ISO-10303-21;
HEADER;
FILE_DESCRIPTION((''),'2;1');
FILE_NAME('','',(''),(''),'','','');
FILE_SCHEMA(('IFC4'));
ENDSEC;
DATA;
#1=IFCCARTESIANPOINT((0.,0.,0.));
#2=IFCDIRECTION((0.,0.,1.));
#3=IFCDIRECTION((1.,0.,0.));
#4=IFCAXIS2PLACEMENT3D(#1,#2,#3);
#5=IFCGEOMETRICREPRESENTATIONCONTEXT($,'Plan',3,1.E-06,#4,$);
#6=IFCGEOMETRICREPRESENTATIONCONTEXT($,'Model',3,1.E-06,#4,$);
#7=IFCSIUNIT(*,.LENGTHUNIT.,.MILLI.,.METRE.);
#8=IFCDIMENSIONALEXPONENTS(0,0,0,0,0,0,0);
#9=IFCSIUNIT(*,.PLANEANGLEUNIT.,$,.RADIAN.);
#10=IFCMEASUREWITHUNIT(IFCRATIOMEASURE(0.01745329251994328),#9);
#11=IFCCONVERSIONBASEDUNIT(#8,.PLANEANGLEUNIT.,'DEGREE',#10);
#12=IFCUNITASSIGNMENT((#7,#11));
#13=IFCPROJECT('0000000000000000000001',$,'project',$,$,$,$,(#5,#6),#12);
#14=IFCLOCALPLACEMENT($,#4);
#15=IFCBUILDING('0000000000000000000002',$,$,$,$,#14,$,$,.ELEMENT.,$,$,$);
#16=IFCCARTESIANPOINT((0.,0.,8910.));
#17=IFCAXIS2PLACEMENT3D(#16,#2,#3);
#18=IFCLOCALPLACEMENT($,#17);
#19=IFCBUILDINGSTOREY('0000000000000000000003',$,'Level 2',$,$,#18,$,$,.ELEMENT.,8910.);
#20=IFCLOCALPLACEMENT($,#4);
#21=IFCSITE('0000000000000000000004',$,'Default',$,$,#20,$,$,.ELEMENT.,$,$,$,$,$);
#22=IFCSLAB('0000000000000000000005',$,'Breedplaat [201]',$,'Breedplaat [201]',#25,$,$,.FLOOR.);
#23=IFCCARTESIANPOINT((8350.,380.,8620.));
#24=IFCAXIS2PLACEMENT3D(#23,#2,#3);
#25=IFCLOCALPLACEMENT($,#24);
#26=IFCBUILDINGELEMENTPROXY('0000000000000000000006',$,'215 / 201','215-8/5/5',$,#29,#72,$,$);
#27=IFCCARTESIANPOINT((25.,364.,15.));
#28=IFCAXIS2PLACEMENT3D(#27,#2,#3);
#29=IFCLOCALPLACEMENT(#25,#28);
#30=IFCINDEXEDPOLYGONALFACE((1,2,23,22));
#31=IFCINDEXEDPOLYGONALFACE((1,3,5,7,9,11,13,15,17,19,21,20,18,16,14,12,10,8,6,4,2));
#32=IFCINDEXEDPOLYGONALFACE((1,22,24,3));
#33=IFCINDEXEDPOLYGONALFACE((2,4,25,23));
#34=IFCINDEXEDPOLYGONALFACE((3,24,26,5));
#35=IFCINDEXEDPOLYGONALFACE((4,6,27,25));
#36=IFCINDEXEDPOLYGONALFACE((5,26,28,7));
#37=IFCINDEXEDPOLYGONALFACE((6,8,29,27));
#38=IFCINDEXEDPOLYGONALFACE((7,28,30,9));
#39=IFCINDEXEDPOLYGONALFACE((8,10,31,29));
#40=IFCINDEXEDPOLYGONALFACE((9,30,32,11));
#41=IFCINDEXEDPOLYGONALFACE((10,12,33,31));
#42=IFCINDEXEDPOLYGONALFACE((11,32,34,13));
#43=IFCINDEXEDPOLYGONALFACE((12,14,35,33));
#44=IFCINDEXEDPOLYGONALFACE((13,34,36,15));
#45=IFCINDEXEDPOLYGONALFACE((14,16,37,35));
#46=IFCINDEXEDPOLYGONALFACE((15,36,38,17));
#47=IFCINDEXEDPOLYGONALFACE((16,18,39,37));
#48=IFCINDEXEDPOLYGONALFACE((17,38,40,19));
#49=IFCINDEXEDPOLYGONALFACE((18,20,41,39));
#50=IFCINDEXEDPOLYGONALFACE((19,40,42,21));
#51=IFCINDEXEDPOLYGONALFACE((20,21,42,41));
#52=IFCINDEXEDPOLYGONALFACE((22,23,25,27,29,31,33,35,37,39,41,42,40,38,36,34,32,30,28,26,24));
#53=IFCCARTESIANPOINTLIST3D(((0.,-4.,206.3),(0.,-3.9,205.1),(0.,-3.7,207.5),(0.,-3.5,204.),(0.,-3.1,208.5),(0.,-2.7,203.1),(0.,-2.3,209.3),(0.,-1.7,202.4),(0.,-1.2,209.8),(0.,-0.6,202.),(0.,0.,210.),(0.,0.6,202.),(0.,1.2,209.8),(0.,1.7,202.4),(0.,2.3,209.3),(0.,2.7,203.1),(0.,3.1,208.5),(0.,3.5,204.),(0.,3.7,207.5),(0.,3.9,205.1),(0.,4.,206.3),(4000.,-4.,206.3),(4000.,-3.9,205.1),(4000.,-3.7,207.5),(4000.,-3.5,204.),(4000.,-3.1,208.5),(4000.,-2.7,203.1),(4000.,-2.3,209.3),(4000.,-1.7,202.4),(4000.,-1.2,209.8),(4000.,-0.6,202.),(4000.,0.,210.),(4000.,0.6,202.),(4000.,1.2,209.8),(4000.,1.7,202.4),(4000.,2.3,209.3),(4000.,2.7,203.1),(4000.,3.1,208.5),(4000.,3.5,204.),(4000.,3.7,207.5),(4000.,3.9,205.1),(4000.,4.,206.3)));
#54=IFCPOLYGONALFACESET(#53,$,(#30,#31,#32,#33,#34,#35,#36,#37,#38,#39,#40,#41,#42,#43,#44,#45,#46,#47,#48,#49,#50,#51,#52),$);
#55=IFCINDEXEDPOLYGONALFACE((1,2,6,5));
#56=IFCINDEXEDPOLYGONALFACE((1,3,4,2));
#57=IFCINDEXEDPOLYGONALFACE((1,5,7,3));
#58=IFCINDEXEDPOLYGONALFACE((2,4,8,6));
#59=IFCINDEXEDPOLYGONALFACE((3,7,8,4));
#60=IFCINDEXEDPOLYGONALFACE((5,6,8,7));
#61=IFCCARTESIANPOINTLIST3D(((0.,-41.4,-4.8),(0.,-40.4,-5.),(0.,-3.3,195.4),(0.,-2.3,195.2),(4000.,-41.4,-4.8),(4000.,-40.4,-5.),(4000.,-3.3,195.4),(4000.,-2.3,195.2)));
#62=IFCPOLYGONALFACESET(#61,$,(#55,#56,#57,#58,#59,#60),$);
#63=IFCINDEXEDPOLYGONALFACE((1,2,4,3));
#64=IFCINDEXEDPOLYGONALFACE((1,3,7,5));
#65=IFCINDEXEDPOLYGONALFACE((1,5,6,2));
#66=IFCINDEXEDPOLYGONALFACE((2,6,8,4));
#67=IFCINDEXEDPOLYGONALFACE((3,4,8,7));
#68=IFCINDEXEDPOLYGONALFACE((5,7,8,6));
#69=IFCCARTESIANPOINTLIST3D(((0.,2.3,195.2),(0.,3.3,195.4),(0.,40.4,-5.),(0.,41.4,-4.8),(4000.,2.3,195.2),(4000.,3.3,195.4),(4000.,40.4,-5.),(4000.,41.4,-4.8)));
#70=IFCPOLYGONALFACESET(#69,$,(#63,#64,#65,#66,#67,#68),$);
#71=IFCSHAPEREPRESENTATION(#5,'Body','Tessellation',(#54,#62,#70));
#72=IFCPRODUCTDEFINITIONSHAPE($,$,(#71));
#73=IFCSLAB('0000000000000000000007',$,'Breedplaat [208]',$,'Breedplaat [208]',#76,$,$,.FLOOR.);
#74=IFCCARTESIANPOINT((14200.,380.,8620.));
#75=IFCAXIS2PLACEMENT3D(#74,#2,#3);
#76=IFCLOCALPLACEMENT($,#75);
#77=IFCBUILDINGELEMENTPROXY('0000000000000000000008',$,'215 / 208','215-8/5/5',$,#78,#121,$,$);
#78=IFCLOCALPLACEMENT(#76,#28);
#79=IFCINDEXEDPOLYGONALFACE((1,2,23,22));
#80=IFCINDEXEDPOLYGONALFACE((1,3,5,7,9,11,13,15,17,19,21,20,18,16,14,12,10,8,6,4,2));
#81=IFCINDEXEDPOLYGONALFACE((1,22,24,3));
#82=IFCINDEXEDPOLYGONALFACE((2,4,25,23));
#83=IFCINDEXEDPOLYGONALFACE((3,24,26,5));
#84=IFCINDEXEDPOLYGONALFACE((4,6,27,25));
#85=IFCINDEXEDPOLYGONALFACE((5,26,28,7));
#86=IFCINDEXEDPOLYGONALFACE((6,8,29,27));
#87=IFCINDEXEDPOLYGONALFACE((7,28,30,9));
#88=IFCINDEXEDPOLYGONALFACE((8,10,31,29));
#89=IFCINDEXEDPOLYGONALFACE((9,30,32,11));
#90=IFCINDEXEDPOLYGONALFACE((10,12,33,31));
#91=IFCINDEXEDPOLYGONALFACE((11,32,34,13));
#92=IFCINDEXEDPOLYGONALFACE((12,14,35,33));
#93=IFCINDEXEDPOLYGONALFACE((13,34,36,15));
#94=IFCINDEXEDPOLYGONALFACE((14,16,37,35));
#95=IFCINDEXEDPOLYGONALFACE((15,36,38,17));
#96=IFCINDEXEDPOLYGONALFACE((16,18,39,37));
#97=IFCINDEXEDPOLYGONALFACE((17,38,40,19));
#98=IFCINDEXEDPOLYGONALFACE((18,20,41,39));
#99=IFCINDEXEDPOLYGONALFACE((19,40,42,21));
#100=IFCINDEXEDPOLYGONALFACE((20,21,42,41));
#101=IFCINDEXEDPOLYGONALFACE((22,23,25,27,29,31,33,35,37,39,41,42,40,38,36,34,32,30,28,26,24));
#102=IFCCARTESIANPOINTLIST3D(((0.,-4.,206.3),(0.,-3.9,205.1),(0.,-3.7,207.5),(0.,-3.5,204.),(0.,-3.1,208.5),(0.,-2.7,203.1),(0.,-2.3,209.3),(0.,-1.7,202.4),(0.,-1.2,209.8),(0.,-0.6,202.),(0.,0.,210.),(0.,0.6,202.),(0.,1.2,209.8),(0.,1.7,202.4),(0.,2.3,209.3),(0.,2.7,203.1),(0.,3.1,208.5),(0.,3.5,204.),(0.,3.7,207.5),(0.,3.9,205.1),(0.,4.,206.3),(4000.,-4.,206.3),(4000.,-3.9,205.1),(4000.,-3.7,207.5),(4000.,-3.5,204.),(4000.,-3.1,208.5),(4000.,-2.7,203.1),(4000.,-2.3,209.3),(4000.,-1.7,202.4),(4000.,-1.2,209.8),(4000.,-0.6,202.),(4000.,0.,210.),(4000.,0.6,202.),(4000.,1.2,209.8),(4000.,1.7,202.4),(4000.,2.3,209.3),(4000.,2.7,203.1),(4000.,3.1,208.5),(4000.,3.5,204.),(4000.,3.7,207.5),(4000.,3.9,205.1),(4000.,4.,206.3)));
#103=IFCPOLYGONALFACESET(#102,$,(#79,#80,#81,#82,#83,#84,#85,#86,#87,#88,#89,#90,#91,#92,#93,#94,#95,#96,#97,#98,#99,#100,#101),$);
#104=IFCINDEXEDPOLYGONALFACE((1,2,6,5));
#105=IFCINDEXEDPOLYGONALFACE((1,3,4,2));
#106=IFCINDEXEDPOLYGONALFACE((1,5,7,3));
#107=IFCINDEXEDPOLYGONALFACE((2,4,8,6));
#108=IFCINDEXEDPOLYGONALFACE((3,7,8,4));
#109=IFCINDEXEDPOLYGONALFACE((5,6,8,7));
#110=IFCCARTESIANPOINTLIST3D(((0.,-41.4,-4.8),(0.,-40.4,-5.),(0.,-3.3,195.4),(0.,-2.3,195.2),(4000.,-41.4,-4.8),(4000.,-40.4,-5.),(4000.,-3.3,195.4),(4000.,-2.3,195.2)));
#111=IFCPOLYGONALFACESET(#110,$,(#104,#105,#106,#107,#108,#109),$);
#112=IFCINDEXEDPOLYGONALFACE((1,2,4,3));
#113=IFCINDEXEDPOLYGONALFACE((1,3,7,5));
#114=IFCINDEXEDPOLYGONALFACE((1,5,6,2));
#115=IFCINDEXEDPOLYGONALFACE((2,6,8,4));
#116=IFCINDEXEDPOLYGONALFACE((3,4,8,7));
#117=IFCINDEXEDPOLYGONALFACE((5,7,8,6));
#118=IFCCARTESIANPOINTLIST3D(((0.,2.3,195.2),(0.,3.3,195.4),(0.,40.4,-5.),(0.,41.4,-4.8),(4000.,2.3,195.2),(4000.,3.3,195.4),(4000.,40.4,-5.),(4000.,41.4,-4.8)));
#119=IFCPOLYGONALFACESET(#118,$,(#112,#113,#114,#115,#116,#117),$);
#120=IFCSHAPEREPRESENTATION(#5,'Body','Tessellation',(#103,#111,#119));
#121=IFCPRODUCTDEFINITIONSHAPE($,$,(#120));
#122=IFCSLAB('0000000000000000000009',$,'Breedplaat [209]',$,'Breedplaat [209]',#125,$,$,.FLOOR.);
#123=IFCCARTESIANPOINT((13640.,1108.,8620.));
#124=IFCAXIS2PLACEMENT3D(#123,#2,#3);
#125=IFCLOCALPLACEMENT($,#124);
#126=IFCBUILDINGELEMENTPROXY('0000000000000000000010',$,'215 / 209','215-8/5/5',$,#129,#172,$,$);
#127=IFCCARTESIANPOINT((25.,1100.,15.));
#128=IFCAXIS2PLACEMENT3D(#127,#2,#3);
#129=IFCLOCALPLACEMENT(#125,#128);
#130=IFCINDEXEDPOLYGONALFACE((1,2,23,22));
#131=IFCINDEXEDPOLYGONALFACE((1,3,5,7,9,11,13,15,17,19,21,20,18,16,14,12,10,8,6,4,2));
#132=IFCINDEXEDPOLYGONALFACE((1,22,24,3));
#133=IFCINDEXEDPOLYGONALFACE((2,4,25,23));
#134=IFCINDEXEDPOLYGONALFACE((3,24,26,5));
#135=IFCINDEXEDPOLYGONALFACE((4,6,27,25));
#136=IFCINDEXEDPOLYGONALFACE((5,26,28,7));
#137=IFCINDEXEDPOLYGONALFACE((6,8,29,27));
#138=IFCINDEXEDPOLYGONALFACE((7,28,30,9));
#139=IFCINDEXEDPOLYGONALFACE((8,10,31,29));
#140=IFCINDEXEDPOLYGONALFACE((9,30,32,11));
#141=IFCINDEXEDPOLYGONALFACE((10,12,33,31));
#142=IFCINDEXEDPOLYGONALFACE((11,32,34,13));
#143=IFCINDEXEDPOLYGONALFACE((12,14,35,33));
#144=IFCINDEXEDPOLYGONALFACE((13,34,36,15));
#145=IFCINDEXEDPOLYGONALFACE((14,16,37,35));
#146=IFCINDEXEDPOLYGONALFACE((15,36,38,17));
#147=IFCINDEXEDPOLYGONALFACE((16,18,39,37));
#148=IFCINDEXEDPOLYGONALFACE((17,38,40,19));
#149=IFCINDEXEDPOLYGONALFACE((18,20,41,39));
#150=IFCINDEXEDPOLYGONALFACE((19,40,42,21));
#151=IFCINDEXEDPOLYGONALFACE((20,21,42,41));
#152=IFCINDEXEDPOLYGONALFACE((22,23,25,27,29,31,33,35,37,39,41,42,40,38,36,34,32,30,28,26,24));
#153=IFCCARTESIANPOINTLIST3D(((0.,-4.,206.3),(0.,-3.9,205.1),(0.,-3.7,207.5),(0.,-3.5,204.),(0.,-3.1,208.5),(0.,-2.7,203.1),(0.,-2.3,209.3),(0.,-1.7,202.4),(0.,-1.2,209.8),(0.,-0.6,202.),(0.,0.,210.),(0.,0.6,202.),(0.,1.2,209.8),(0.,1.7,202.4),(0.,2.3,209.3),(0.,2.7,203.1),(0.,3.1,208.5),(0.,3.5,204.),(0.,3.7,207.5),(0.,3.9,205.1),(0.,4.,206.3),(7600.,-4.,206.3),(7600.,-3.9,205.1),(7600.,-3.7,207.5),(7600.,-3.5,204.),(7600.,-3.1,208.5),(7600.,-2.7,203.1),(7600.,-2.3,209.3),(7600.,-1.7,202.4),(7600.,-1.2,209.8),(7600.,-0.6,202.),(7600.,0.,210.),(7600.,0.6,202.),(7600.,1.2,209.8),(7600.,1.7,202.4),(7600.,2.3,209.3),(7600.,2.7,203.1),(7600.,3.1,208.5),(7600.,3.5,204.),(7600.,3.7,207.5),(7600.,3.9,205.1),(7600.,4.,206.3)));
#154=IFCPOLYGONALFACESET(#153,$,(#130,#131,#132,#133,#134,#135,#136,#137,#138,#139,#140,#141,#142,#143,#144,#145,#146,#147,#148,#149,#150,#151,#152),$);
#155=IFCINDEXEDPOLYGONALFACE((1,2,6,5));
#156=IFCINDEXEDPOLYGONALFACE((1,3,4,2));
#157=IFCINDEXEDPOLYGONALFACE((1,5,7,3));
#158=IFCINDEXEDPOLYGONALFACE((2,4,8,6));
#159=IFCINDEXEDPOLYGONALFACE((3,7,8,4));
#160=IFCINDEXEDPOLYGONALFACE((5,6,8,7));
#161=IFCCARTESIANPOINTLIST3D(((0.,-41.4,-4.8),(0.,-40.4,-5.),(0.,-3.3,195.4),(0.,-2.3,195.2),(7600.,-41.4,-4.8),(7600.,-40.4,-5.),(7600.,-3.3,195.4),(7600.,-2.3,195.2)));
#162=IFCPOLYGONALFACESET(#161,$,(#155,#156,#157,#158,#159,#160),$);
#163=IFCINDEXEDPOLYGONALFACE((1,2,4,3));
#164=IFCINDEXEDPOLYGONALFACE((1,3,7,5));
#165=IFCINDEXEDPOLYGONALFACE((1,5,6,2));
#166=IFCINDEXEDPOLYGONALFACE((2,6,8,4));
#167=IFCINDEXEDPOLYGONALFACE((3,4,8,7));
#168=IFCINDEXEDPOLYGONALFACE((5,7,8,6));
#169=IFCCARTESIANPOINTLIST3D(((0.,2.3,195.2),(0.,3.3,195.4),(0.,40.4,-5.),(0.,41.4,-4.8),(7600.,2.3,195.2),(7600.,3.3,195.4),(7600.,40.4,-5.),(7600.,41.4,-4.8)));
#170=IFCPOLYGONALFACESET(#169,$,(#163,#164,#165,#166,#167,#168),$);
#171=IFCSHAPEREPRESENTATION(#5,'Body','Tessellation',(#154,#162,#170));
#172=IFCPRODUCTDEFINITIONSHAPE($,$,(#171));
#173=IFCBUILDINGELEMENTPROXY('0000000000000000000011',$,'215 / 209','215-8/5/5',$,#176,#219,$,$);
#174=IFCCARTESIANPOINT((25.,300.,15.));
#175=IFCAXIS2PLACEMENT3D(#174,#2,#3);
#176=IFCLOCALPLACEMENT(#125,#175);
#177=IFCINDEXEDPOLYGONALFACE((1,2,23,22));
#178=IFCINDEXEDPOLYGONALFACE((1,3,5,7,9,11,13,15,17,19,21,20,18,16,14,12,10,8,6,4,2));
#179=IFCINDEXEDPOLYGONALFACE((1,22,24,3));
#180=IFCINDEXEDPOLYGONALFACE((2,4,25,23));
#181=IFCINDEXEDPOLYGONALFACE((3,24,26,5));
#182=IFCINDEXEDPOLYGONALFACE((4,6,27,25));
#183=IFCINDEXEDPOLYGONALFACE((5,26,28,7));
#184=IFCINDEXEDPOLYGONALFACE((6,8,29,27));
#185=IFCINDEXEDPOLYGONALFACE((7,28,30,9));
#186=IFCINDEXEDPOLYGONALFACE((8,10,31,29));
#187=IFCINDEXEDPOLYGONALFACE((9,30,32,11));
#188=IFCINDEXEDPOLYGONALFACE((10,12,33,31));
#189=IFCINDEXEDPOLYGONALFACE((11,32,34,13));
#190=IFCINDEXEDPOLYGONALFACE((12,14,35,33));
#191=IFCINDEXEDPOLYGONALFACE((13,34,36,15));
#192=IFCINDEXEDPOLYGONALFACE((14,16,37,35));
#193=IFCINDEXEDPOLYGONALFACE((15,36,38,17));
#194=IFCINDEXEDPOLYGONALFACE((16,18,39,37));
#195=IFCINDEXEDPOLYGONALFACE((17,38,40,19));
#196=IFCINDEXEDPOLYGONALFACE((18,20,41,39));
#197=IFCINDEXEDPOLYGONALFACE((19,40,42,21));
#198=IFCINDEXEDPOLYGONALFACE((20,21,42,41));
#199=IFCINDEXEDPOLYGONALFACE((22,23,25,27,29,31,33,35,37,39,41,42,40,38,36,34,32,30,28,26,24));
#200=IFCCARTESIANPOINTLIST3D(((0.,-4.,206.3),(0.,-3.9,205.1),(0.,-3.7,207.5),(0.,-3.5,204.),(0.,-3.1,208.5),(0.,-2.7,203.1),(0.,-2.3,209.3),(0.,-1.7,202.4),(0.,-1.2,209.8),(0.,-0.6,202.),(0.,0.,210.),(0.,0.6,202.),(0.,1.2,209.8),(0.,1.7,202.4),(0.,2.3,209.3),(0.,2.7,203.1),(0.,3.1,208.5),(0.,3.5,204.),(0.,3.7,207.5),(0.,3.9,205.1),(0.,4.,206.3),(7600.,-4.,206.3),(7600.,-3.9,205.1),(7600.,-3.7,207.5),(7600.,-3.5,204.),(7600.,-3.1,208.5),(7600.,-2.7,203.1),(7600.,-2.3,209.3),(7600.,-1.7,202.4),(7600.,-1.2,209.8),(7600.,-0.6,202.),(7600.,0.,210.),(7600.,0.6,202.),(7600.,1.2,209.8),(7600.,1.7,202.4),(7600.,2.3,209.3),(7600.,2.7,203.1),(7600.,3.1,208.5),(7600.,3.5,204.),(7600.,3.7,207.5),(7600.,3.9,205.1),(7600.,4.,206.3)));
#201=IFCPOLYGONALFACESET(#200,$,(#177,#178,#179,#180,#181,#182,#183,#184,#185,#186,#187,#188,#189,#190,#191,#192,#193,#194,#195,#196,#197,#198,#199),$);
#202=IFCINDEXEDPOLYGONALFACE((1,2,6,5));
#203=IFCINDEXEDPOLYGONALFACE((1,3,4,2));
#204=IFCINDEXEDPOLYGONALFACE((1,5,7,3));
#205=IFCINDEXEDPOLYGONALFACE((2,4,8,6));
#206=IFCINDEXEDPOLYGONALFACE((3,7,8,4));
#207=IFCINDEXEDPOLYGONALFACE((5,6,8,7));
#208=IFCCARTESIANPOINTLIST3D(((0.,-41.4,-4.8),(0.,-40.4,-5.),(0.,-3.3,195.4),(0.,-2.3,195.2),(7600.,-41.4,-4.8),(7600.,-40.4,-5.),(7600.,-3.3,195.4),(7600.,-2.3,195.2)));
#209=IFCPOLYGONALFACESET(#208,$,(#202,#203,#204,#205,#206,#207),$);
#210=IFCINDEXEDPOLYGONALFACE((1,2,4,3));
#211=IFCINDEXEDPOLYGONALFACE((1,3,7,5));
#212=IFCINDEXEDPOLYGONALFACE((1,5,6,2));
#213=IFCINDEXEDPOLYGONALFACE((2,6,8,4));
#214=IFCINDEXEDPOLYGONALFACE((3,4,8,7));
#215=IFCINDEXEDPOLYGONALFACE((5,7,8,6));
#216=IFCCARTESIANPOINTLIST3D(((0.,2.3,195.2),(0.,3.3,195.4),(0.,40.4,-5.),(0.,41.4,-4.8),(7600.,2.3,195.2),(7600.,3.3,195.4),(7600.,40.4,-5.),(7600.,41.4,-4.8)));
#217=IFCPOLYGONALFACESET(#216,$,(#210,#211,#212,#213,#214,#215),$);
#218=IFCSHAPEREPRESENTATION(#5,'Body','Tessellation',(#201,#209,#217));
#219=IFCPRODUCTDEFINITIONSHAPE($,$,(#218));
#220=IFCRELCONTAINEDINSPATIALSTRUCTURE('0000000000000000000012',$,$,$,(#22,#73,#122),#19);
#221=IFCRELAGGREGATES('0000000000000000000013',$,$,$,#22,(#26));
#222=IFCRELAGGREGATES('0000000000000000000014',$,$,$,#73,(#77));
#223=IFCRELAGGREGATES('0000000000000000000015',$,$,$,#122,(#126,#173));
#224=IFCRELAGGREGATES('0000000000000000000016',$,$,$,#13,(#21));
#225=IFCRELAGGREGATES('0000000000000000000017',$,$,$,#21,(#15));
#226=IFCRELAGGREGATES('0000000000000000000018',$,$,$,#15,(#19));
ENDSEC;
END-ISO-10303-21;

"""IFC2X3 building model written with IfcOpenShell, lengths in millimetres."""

from ifc_helpers import new_model, entity, si_unit, converted_unit, frame, origin_with_axes, origin_2d_with_axis, place, context, project, spatial, rectangle, circle, extrude, element, aggregate, save


model = new_model("IFC2X3")

# Units and contexts
plan_context = context("Plan", 3, precision=1e-06, world=origin_with_axes())
model_context = context("Model", 3, precision=1e-06, world=origin_with_axes())
ifc_project = project(units=[si_unit("LENGTHUNIT", "METRE", prefix="MILLI"), converted_unit("PLANEANGLEUNIT", "DEGREE", entity("IfcRatioMeasure", 0.01745329251994328), si_unit("PLANEANGLEUNIT", "RADIAN"), dimensions=[0, 0, 0, 0, 0, 0, 0])], contexts=[plan_context, model_context])

# Site, building, storey
site_placement = place(None, origin_with_axes())
site = spatial("IfcSite", under=ifc_project, at=site_placement, Name="Default", CompositionType="ELEMENT")
building_placement = place(None, origin_with_axes())
building = spatial("IfcBuilding", under=site, at=building_placement, CompositionType="ELEMENT")
storey_placement = place(None, frame((0.0, 0.0, 8910.0), z_axis=(0.0, 0.0, 1.0), x_axis=(1.0, 0.0, 0.0)))
storey = spatial("IfcBuildingStorey", under=building, at=storey_placement, Name="Level 2", CompositionType="ELEMENT", Elevation=8910.0)

# Slab, building element proxy
slab_1_placement = place(None, frame((8350.0, 380.0, 8620.0), z_axis=(0.0, 0.0, 1.0), x_axis=(1.0, 0.0, 0.0)))
slab_1 = element("IfcSlab", 1, at=slab_1_placement, inside=storey, Name="Breedplaat [201]", ObjectType="Breedplaat [201]", PredefinedType="FLOOR")
proxy_1_placement = place(slab_1_placement, frame((25.0, 364.0, 15.0), z_axis=(0.0, 0.0, 1.0), x_axis=(1.0, 0.0, 0.0)))
proxy_1 = element("IfcBuildingElementProxy", 2, at=proxy_1_placement, Name="215 / 201", Description="215-8/5/5", context=plan_context, shape_type="SweptSolid", body=[
    extrude(circle(Radius=4.0, at=origin_2d_with_axis()), frame((0.0, 0.0, 206.0), z_axis=(1.0, 0.0, 0.0), x_axis=(0.0, 0.0, 1.0)), (0.0, 0.0, 1.0), 4000.0),
    extrude(rectangle(XDim=203.8, YDim=1.0, at=origin_2d_with_axis()), frame((0.0, -21.9, 95.2), z_axis=(1.0, 0.0, 0.0), x_axis=(0.0, 0.187112, 0.982339)), (0.0, 0.0, 1.0), 4000.0),
    extrude(rectangle(XDim=203.8, YDim=1.0, at=origin_2d_with_axis()), frame((0.0, 21.9, 95.2), z_axis=(1.0, 0.0, 0.0), x_axis=(0.0, -0.187112, 0.982339)), (0.0, 0.0, 1.0), 4000.0),
])
aggregate(slab_1, [proxy_1])

# Slab, building element proxy
slab_2_placement = place(None, frame((14200.0, 380.0, 8620.0), z_axis=(0.0, 0.0, 1.0), x_axis=(1.0, 0.0, 0.0)))
slab_2 = element("IfcSlab", 3, at=slab_2_placement, inside=storey, Name="Breedplaat [208]", ObjectType="Breedplaat [208]", PredefinedType="FLOOR")
proxy_2_placement = place(slab_2_placement, frame((25.0, 364.0, 15.0), z_axis=(0.0, 0.0, 1.0), x_axis=(1.0, 0.0, 0.0)))
proxy_2 = element("IfcBuildingElementProxy", 4, at=proxy_2_placement, Name="215 / 208", Description="215-8/5/5", context=plan_context, shape_type="SweptSolid", body=[
    extrude(circle(Radius=4.0, at=origin_2d_with_axis()), frame((0.0, 0.0, 206.0), z_axis=(1.0, 0.0, 0.0), x_axis=(0.0, 0.0, 1.0)), (0.0, 0.0, 1.0), 4000.0),
    extrude(rectangle(XDim=203.8, YDim=1.0, at=origin_2d_with_axis()), frame((0.0, -21.9, 95.2), z_axis=(1.0, 0.0, 0.0), x_axis=(0.0, 0.187112, 0.982339)), (0.0, 0.0, 1.0), 4000.0),
    extrude(rectangle(XDim=203.8, YDim=1.0, at=origin_2d_with_axis()), frame((0.0, 21.9, 95.2), z_axis=(1.0, 0.0, 0.0), x_axis=(0.0, -0.187112, 0.982339)), (0.0, 0.0, 1.0), 4000.0),
])
aggregate(slab_2, [proxy_2])

# Slab, building element proxies
slab_3_placement = place(None, frame((13640.0, 1108.0, 8620.0), z_axis=(0.0, 0.0, 1.0), x_axis=(1.0, 0.0, 0.0)))
slab_3 = element("IfcSlab", 5, at=slab_3_placement, inside=storey, Name="Breedplaat [209]", ObjectType="Breedplaat [209]", PredefinedType="FLOOR")
proxy_3_placement = place(slab_3_placement, frame((25.0, 1100.0, 15.0), z_axis=(0.0, 0.0, 1.0), x_axis=(1.0, 0.0, 0.0)))
proxy_3 = element("IfcBuildingElementProxy", 6, at=proxy_3_placement, Name="215 / 209", Description="215-8/5/5", context=plan_context, shape_type="SweptSolid", body=[
    extrude(circle(Radius=4.0, at=origin_2d_with_axis()), frame((0.0, 0.0, 206.0), z_axis=(1.0, 0.0, 0.0), x_axis=(0.0, 0.0, 1.0)), (0.0, 0.0, 1.0), 7600.0),
    extrude(rectangle(XDim=203.8, YDim=1.0, at=origin_2d_with_axis()), frame((0.0, -21.9, 95.2), z_axis=(1.0, 0.0, 0.0), x_axis=(0.0, 0.187112, 0.982339)), (0.0, 0.0, 1.0), 7600.0),
    extrude(rectangle(XDim=203.8, YDim=1.0, at=origin_2d_with_axis()), frame((0.0, 21.9, 95.2), z_axis=(1.0, 0.0, 0.0), x_axis=(0.0, -0.187112, 0.982339)), (0.0, 0.0, 1.0), 7600.0),
])
proxy_4_placement = place(slab_3_placement, frame((25.0, 300.0, 15.0), z_axis=(0.0, 0.0, 1.0), x_axis=(1.0, 0.0, 0.0)))
proxy_4 = element("IfcBuildingElementProxy", 7, at=proxy_4_placement, Name="215 / 209", Description="215-8/5/5", context=plan_context, shape_type="SweptSolid", body=[
    extrude(circle(Radius=4.0, at=origin_2d_with_axis()), frame((0.0, 0.0, 206.0), z_axis=(1.0, 0.0, 0.0), x_axis=(0.0, 0.0, 1.0)), (0.0, 0.0, 1.0), 7600.0),
    extrude(rectangle(XDim=203.8, YDim=1.0, at=origin_2d_with_axis()), frame((0.0, -21.9, 95.2), z_axis=(1.0, 0.0, 0.0), x_axis=(0.0, 0.187112, 0.982339)), (0.0, 0.0, 1.0), 7600.0),
    extrude(rectangle(XDim=203.8, YDim=1.0, at=origin_2d_with_axis()), frame((0.0, 21.9, 95.2), z_axis=(1.0, 0.0, 0.0), x_axis=(0.0, -0.187112, 0.982339)), (0.0, 0.0, 1.0), 7600.0),
])
aggregate(slab_3, [proxy_3, proxy_4])

save(model, "model.ifc")
